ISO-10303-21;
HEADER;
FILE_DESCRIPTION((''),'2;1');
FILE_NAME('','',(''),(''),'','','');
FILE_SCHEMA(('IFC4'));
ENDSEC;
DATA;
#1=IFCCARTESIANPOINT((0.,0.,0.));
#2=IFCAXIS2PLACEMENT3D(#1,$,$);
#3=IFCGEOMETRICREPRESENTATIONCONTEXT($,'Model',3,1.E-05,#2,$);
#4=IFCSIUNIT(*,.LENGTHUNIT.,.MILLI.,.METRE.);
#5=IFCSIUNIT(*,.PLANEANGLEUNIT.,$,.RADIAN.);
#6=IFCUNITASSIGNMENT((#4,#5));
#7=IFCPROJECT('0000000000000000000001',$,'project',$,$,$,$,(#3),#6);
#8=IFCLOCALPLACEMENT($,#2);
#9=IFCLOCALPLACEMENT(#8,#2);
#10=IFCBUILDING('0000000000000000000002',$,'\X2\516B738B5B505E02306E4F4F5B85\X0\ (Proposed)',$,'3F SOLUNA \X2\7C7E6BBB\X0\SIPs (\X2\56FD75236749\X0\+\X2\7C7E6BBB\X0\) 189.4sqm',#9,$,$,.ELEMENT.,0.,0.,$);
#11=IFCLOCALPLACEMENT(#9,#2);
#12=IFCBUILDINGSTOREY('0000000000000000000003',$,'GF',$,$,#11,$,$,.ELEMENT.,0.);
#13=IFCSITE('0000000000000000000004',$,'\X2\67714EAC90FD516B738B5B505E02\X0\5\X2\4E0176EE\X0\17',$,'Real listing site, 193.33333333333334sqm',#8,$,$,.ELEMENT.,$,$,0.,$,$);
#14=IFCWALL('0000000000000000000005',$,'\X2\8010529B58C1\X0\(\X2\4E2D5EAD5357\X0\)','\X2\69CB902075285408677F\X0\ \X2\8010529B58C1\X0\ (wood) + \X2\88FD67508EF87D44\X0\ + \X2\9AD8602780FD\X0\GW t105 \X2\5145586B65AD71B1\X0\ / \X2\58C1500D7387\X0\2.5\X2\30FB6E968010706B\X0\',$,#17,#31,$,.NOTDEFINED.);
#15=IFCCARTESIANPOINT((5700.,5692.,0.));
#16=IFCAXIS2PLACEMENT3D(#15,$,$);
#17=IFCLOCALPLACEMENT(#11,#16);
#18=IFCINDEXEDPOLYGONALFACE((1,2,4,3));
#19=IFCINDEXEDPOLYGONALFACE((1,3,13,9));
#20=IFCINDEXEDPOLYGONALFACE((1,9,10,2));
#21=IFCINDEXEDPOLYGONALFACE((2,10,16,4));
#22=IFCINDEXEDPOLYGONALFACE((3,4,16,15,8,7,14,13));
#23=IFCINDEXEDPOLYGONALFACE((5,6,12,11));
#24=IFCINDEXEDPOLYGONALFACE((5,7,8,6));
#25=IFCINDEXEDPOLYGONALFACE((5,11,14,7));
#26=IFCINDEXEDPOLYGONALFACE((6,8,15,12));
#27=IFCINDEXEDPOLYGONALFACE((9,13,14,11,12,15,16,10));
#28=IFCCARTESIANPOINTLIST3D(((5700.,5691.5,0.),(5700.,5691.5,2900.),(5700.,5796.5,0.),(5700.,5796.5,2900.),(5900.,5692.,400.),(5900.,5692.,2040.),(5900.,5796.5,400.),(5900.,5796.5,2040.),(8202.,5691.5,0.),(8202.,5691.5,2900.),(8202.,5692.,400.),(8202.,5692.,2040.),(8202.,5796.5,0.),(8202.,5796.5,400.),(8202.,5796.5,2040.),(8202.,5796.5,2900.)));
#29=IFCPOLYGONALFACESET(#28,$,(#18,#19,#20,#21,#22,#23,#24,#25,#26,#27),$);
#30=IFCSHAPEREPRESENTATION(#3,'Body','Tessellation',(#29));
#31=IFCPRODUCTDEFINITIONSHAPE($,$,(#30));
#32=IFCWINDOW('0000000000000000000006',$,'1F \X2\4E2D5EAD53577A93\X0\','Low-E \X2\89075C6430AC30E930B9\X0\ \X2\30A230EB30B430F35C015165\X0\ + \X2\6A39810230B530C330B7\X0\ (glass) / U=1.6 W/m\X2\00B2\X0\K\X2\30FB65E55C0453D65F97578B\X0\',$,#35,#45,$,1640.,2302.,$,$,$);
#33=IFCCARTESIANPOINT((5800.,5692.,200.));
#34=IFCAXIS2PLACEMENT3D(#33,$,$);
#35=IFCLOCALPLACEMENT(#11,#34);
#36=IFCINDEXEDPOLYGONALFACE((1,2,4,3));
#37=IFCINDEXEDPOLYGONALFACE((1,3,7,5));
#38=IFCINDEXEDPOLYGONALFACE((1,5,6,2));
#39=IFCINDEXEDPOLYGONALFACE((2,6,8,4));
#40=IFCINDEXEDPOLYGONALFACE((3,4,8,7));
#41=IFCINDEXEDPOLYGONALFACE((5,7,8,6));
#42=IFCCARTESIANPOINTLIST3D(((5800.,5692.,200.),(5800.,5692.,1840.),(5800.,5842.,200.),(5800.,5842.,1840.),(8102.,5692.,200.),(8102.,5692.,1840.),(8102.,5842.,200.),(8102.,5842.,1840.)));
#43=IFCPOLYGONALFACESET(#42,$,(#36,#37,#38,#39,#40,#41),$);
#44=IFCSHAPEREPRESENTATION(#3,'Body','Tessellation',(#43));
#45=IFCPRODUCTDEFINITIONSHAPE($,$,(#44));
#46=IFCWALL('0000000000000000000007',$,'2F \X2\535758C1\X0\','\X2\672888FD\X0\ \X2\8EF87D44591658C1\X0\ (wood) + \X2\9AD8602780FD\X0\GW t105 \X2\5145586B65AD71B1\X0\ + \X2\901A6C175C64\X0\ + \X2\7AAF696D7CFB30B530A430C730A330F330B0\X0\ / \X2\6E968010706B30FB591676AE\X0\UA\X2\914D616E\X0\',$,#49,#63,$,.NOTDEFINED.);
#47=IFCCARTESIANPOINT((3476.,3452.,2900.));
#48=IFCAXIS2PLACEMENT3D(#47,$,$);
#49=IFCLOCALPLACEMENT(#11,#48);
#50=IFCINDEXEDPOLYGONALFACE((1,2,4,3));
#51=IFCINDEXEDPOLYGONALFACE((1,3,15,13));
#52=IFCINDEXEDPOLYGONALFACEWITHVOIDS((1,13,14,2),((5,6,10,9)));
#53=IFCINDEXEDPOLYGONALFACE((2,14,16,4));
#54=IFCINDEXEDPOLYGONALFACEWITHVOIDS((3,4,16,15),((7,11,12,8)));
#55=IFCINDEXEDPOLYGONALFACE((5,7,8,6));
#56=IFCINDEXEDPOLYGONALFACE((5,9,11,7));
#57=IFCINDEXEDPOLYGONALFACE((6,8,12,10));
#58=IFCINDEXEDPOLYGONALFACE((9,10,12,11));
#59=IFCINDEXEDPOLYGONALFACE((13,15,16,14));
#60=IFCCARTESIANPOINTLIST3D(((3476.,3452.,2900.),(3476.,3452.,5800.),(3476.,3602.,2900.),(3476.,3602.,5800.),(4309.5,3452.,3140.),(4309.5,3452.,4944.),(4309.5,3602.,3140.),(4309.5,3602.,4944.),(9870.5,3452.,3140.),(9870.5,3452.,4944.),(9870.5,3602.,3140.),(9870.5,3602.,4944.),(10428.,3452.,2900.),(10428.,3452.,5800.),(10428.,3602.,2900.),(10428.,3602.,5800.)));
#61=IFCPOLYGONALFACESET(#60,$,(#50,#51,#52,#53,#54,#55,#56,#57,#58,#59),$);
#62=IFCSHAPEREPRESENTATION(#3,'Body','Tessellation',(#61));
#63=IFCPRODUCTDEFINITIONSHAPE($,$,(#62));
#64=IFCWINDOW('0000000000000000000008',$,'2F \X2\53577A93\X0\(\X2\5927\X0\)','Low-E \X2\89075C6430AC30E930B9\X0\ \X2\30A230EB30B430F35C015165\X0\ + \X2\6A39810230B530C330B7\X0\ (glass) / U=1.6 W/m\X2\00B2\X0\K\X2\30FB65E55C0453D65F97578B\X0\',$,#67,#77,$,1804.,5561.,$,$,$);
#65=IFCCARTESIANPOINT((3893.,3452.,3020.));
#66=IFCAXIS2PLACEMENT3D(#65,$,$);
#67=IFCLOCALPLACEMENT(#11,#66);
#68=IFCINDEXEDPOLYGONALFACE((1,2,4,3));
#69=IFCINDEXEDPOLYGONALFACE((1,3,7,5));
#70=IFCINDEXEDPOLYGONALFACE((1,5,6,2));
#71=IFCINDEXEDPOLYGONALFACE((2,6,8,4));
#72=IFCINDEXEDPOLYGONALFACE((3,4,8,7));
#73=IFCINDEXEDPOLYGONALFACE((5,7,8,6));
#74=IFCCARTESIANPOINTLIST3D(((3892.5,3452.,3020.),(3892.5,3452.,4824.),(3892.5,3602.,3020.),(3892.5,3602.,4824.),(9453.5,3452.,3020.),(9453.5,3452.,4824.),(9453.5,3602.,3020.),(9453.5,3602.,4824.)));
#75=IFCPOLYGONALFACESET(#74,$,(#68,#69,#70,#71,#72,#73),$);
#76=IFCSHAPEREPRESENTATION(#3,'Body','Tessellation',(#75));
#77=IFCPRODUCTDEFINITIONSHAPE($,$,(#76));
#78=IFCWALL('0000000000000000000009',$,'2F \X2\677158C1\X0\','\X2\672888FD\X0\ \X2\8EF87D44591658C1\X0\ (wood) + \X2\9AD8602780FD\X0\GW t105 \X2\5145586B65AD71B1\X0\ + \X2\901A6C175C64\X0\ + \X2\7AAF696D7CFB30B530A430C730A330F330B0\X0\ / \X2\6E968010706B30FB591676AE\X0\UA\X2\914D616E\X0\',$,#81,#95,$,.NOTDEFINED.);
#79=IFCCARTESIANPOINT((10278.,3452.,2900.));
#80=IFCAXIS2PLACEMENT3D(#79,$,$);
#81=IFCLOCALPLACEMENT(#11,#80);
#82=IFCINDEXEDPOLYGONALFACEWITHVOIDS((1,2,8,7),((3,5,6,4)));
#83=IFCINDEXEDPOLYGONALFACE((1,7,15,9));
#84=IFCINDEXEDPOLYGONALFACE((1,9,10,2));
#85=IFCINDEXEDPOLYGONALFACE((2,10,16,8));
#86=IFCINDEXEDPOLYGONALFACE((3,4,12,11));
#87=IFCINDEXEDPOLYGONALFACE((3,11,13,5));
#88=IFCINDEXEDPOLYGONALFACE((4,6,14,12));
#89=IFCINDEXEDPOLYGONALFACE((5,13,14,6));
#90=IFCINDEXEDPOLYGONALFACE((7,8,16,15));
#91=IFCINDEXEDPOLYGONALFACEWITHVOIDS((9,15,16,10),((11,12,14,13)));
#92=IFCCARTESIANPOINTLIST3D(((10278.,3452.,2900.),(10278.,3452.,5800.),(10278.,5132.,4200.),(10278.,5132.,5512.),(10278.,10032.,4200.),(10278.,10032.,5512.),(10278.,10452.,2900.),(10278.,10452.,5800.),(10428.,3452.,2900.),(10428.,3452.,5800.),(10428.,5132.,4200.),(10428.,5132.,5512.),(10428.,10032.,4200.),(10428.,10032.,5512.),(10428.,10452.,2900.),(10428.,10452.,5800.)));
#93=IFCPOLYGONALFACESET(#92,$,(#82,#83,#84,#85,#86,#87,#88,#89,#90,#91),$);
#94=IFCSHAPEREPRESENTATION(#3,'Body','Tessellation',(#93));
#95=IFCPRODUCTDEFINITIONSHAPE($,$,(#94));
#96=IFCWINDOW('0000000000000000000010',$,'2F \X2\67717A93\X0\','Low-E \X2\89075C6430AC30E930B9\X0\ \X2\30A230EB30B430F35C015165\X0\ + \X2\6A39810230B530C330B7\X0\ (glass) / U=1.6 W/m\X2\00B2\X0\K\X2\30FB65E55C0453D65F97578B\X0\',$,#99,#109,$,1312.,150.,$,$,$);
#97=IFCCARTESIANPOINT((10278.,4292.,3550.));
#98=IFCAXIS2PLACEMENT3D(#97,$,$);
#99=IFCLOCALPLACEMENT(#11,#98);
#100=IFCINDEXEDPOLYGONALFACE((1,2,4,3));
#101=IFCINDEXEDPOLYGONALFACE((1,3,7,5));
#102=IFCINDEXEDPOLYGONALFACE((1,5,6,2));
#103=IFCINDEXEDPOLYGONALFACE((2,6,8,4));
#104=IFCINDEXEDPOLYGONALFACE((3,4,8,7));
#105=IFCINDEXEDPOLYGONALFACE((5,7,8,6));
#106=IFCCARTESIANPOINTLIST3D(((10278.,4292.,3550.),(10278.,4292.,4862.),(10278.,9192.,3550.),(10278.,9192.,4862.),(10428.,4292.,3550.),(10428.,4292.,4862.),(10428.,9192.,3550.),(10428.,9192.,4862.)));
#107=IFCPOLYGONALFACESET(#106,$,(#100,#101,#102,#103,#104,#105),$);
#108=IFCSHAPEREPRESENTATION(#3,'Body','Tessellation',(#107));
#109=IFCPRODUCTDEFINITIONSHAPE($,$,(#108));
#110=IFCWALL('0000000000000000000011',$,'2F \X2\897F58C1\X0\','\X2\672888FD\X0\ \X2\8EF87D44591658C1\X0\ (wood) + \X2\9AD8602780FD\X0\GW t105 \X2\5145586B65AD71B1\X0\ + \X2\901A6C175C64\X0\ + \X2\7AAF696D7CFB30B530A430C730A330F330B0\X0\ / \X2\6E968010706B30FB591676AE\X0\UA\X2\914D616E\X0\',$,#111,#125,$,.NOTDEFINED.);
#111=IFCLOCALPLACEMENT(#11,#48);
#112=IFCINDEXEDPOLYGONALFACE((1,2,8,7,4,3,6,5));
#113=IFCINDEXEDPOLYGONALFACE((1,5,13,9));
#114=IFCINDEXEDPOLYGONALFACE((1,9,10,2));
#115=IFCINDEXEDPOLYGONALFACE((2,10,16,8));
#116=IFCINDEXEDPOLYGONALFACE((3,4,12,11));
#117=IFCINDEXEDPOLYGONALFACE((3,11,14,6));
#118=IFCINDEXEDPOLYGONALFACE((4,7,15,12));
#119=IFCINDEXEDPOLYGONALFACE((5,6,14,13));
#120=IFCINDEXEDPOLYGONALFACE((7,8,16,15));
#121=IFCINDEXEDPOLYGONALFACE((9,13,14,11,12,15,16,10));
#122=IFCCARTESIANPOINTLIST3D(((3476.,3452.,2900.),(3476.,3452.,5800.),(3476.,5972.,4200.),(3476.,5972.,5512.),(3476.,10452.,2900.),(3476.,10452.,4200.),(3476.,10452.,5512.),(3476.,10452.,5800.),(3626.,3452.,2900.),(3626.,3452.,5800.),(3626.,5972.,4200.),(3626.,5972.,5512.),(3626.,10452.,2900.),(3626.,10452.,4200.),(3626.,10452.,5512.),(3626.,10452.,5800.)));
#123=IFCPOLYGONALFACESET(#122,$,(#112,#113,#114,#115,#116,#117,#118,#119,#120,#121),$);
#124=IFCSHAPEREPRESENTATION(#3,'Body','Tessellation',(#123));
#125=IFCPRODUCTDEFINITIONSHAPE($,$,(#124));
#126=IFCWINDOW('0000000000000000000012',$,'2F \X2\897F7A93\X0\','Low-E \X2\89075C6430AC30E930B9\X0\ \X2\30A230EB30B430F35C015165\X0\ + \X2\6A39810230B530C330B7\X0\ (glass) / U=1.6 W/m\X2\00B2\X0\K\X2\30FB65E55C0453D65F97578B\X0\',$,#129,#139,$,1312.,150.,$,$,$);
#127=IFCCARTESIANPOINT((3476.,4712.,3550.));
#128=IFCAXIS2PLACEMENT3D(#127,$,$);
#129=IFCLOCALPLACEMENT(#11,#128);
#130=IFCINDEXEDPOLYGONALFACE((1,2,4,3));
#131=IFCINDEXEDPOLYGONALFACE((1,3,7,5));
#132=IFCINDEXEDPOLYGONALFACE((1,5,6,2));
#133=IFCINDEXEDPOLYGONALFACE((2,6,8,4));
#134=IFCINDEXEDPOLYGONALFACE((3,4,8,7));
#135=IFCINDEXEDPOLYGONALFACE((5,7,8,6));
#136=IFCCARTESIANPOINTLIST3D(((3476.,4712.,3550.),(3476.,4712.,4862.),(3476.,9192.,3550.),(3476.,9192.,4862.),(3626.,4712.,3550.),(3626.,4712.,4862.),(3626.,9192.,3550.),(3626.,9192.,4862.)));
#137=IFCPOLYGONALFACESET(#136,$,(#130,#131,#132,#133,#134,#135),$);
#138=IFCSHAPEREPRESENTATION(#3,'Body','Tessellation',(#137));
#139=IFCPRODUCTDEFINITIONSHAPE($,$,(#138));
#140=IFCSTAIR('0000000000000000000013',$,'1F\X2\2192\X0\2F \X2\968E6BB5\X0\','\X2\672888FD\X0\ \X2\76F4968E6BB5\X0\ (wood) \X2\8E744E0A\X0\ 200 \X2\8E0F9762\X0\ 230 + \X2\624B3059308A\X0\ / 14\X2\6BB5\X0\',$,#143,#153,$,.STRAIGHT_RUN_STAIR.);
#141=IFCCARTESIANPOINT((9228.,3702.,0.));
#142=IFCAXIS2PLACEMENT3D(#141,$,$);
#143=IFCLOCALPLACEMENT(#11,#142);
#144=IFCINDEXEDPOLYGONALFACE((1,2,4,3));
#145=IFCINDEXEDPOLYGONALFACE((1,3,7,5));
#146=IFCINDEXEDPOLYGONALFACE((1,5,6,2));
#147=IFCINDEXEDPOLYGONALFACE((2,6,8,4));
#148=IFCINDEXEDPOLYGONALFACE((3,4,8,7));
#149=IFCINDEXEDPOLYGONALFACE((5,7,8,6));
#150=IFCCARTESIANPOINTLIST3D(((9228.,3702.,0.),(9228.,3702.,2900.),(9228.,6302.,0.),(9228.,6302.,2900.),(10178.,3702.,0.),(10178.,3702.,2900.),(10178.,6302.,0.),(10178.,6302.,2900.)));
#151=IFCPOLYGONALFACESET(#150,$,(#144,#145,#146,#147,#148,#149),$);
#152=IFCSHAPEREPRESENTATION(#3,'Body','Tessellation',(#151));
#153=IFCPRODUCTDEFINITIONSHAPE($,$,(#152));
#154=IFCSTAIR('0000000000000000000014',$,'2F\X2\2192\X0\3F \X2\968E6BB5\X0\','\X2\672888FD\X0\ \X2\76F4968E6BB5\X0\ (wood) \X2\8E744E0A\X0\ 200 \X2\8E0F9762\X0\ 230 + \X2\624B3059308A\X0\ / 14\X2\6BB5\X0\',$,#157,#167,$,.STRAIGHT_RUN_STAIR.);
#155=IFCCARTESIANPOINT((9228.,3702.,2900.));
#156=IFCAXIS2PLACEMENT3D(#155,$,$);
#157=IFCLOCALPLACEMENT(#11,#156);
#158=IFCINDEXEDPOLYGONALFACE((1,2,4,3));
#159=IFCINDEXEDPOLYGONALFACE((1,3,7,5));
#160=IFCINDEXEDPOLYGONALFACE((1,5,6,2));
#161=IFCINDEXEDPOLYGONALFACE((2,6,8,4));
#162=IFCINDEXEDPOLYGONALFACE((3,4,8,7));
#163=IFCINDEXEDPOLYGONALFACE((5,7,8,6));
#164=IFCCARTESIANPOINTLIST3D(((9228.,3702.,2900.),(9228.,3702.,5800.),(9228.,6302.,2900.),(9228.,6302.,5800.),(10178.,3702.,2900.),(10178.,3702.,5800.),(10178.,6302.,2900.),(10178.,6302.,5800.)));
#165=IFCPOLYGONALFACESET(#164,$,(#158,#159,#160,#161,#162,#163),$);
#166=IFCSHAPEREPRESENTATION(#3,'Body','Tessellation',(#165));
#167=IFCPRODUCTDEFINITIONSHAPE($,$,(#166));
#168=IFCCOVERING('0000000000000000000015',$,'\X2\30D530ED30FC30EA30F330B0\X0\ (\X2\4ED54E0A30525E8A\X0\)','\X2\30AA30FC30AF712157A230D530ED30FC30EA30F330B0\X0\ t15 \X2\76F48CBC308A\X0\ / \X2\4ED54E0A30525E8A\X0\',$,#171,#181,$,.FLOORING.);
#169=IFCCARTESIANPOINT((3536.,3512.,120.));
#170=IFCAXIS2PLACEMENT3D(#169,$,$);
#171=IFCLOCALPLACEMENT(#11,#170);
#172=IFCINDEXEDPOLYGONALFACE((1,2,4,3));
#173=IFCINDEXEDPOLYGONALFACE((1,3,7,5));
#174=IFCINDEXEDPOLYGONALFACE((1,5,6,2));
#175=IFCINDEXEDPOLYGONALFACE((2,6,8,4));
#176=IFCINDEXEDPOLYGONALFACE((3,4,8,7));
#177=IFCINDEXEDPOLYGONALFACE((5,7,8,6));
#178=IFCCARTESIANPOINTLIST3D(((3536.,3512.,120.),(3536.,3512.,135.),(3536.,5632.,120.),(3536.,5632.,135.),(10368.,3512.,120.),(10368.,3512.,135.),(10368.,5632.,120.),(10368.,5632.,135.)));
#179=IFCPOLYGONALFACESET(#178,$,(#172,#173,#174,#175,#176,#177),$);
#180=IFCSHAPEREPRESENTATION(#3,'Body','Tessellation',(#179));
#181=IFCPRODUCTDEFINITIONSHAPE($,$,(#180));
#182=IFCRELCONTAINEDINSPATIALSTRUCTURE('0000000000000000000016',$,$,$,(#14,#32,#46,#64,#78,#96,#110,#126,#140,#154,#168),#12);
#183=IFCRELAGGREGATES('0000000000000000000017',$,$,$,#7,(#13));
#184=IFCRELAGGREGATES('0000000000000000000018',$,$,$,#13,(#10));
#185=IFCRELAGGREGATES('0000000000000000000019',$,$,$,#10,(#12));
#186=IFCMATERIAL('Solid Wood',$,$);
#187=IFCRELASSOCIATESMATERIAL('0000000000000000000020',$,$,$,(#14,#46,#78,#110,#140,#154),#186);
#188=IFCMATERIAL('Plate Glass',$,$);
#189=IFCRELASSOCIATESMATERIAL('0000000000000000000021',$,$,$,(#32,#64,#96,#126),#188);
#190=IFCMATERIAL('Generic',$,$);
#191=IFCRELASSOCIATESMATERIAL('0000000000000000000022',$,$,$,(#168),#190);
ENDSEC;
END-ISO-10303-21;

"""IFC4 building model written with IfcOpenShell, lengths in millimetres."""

from ifc_helpers import new_model, si_unit, frame, frame_2d, origin, place, context, project, spatial, rectangle, extrude, material, element, fill, save


model = new_model("IFC4")

# Units and contexts
model_context = context("Model", 3, precision=1e-05, world=origin())
ifc_project = project(units=[si_unit("LENGTHUNIT", "METRE", prefix="MILLI"), si_unit("PLANEANGLEUNIT", "RADIAN")], contexts=[model_context])

# Site, building, storey
site_placement = place(None, origin())
site = spatial("IfcSite", under=ifc_project, at=site_placement, Name="東京都八王子市5丁目17", ObjectType="Real listing site, 193.33333333333334sqm", CompositionType="ELEMENT", RefElevation=0.0)
building_placement = place(site_placement, origin())
building = spatial("IfcBuilding", under=site, at=building_placement, Name="八王子市の住宅 (Proposed)", ObjectType="3F SOLUNA 籾殻SIPs (国産杉+籾殻) 189.4sqm", CompositionType="ELEMENT", ElevationOfRefHeight=0.0, ElevationOfTerrain=0.0)
storey_placement = place(building_placement, origin())
storey = spatial("IfcBuildingStorey", under=building, at=storey_placement, Name="GF", CompositionType="ELEMENT", Elevation=0.0)

# Shared definitions
ifc_material_1 = material(Name="Solid Wood")
ifc_material_2 = material(Name="Generic")

# Shared definitions
ifc_material_3 = material(Name="Plate Glass")

# Walls, openings, windows
wall_1_placement = place(storey_placement, frame((5700.0, 5692.0, 0.0)))
wall_1 = element("IfcWall", 1, at=wall_1_placement, inside=storey, material=ifc_material_1, Name="耐力壁(中庭南)", Description="構造用合板 耐力壁 (wood) + 製材軸組 + 高性能GW t105 充填断熱 / 壁倍率2.5・準耐火", PredefinedType="NOTDEFINED", context=model_context, shape_type="SweptSolid", body=[
    extrude(rectangle(XDim=2502.0, YDim=105.0, at=frame_2d((1251.0, 52.0))), frame((5700.0, 5692.0, 0.0)), (0.0, 0.0, 1.0), 2900.0),
])
opening_1_placement = place(storey_placement, frame((5800.0, 5692.0, 200.0)))
opening_1 = element("IfcOpeningElement", 2, at=opening_1_placement, cuts=wall_1, PredefinedType="NOTDEFINED", context=model_context, shape_type="SweptSolid", body=[
    extrude(rectangle(XDim=2302.0, YDim=150.0, at=frame_2d((1151.0, 75.0))), frame((5800.0, 5692.0, 200.0)), (0.0, 0.0, 1.0), 1640.0),
])
window_1_placement = place(storey_placement, frame((5800.0, 5692.0, 200.0)))
window_1 = element("IfcWindow", 3, at=window_1_placement, inside=storey, material=ifc_material_3, Name="1F 中庭南窓", Description="Low-E 複層ガラス アルゴン封入 + 樹脂サッシ (glass) / U=1.6 W/m²K・日射取得型", OverallHeight=1640.0, OverallWidth=2302.0, context=model_context, shape_type="SweptSolid", body=[
    extrude(rectangle(XDim=2302.0, YDim=150.0, at=frame_2d((1151.0, 75.0))), frame((5800.0, 5692.0, 200.0)), (0.0, 0.0, 1.0), 1640.0),
])
fill(opening_1, window_1)
wall_2_placement = place(storey_placement, frame((3476.0, 3452.0, 2900.0)))
wall_2 = element("IfcWall", 4, at=wall_2_placement, inside=storey, material=ifc_material_1, Name="2F 南壁", Description="木製 軸組外壁 (wood) + 高性能GW t105 充填断熱 + 通気層 + 窯業系サイディング / 準耐火・外皮UA配慮", PredefinedType="NOTDEFINED", context=model_context, shape_type="SweptSolid", body=[
    extrude(rectangle(XDim=6952.0, YDim=150.0, at=frame_2d((3476.0, 75.0))), frame((3476.0, 3452.0, 2900.0)), (0.0, 0.0, 1.0), 2900.0),
])
opening_2_placement = place(storey_placement, frame((3893.0, 3452.0, 3020.0)))
opening_2 = element("IfcOpeningElement", 5, at=opening_2_placement, cuts=wall_2, PredefinedType="NOTDEFINED", context=model_context, shape_type="SweptSolid", body=[
    extrude(rectangle(XDim=5561.0, YDim=150.0, at=frame_2d((2780.0, 75.0))), frame((3893.0, 3452.0, 3020.0)), (0.0, 0.0, 1.0), 1804.0),
])
window_2_placement = place(storey_placement, frame((3893.0, 3452.0, 3020.0)))
window_2 = element("IfcWindow", 6, at=window_2_placement, inside=storey, material=ifc_material_3, Name="2F 南窓(大)", Description="Low-E 複層ガラス アルゴン封入 + 樹脂サッシ (glass) / U=1.6 W/m²K・日射取得型", OverallHeight=1804.0, OverallWidth=5561.0, context=model_context, shape_type="SweptSolid", body=[
    extrude(rectangle(XDim=5561.0, YDim=150.0, at=frame_2d((2780.0, 75.0))), frame((3893.0, 3452.0, 3020.0)), (0.0, 0.0, 1.0), 1804.0),
])
fill(opening_2, window_2)
wall_3_placement = place(storey_placement, frame((10278.0, 3452.0, 2900.0)))
wall_3 = element("IfcWall", 7, at=wall_3_placement, inside=storey, material=ifc_material_1, Name="2F 東壁", Description="木製 軸組外壁 (wood) + 高性能GW t105 充填断熱 + 通気層 + 窯業系サイディング / 準耐火・外皮UA配慮", PredefinedType="NOTDEFINED", context=model_context, shape_type="SweptSolid", body=[
    extrude(rectangle(XDim=150.0, YDim=7000.0, at=frame_2d((75.0, 3500.0))), frame((10278.0, 3452.0, 2900.0)), (0.0, 0.0, 1.0), 2900.0),
])
opening_3_placement = place(storey_placement, frame((10278.0, 4292.0, 3550.0)))
opening_3 = element("IfcOpeningElement", 8, at=opening_3_placement, cuts=wall_3, PredefinedType="NOTDEFINED", context=model_context, shape_type="SweptSolid", body=[
    extrude(rectangle(XDim=150.0, YDim=4900.0, at=frame_2d((75.0, 2450.0))), frame((10278.0, 4292.0, 3550.0)), (0.0, 0.0, 1.0), 1312.0),
])
window_3_placement = place(storey_placement, frame((10278.0, 4292.0, 3550.0)))
window_3 = element("IfcWindow", 9, at=window_3_placement, inside=storey, material=ifc_material_3, Name="2F 東窓", Description="Low-E 複層ガラス アルゴン封入 + 樹脂サッシ (glass) / U=1.6 W/m²K・日射取得型", OverallHeight=1312.0, OverallWidth=150.0, context=model_context, shape_type="SweptSolid", body=[
    extrude(rectangle(XDim=150.0, YDim=4900.0, at=frame_2d((75.0, 2450.0))), frame((10278.0, 4292.0, 3550.0)), (0.0, 0.0, 1.0), 1312.0),
])
fill(opening_3, window_3)
wall_4_placement = place(storey_placement, frame((3476.0, 3452.0, 2900.0)))
wall_4 = element("IfcWall", 10, at=wall_4_placement, inside=storey, material=ifc_material_1, Name="2F 西壁", Description="木製 軸組外壁 (wood) + 高性能GW t105 充填断熱 + 通気層 + 窯業系サイディング / 準耐火・外皮UA配慮", PredefinedType="NOTDEFINED", context=model_context, shape_type="SweptSolid", body=[
    extrude(rectangle(XDim=150.0, YDim=7000.0, at=frame_2d((75.0, 3500.0))), frame((3476.0, 3452.0, 2900.0)), (0.0, 0.0, 1.0), 2900.0),
])
opening_4_placement = place(storey_placement, frame((3476.0, 4712.0, 3550.0)))
opening_4 = element("IfcOpeningElement", 11, at=opening_4_placement, cuts=wall_4, PredefinedType="NOTDEFINED", context=model_context, shape_type="SweptSolid", body=[
    extrude(rectangle(XDim=150.0, YDim=4480.0, at=frame_2d((75.0, 2240.0))), frame((3476.0, 4712.0, 3550.0)), (0.0, 0.0, 1.0), 1312.0),
])
window_4_placement = place(storey_placement, frame((3476.0, 4712.0, 3550.0)))
window_4 = element("IfcWindow", 12, at=window_4_placement, inside=storey, material=ifc_material_3, Name="2F 西窓", Description="Low-E 複層ガラス アルゴン封入 + 樹脂サッシ (glass) / U=1.6 W/m²K・日射取得型", OverallHeight=1312.0, OverallWidth=150.0, context=model_context, shape_type="SweptSolid", body=[
    extrude(rectangle(XDim=150.0, YDim=4480.0, at=frame_2d((75.0, 2240.0))), frame((3476.0, 4712.0, 3550.0)), (0.0, 0.0, 1.0), 1312.0),
])
fill(opening_4, window_4)

# Stairs
stair_1_placement = place(storey_placement, frame((9228.0, 3702.0, 0.0)))
element("IfcStair", 13, at=stair_1_placement, inside=storey, material=ifc_material_1, Name="1F→2F 階段", Description="木製 直階段 (wood) 蹴上 200 踏面 230 + 手すり / 14段", PredefinedType="STRAIGHT_RUN_STAIR", context=model_context, shape_type="SweptSolid", body=[
    extrude(rectangle(XDim=950.0, YDim=2600.0, at=frame_2d((475.0, 1300.0))), frame((9228.0, 3702.0, 0.0)), (0.0, 0.0, 1.0), 2900.0),
])
stair_2_placement = place(storey_placement, frame((9228.0, 3702.0, 2900.0)))
element("IfcStair", 14, at=stair_2_placement, inside=storey, material=ifc_material_1, Name="2F→3F 階段", Description="木製 直階段 (wood) 蹴上 200 踏面 230 + 手すり / 14段", PredefinedType="STRAIGHT_RUN_STAIR", context=model_context, shape_type="SweptSolid", body=[
    extrude(rectangle(XDim=950.0, YDim=2600.0, at=frame_2d((475.0, 1300.0))), frame((9228.0, 3702.0, 2900.0)), (0.0, 0.0, 1.0), 2900.0),
])

# Covering
covering_placement = place(storey_placement, frame((3536.0, 3512.0, 120.0)))
element("IfcCovering", 15, at=covering_placement, inside=storey, material=ifc_material_2, Name="フローリング (仕上げ床)", Description="オーク無垢フローリング t15 直貼り / 仕上げ床", PredefinedType="FLOORING", context=model_context, shape_type="SweptSolid", body=[
    extrude(rectangle(XDim=6832.0, YDim=2120.0, at=frame_2d((3416.0, 1060.0))), frame((3536.0, 3512.0, 120.0)), (0.0, 0.0, 1.0), 15.0),
])

save(model, "model.ifc")
